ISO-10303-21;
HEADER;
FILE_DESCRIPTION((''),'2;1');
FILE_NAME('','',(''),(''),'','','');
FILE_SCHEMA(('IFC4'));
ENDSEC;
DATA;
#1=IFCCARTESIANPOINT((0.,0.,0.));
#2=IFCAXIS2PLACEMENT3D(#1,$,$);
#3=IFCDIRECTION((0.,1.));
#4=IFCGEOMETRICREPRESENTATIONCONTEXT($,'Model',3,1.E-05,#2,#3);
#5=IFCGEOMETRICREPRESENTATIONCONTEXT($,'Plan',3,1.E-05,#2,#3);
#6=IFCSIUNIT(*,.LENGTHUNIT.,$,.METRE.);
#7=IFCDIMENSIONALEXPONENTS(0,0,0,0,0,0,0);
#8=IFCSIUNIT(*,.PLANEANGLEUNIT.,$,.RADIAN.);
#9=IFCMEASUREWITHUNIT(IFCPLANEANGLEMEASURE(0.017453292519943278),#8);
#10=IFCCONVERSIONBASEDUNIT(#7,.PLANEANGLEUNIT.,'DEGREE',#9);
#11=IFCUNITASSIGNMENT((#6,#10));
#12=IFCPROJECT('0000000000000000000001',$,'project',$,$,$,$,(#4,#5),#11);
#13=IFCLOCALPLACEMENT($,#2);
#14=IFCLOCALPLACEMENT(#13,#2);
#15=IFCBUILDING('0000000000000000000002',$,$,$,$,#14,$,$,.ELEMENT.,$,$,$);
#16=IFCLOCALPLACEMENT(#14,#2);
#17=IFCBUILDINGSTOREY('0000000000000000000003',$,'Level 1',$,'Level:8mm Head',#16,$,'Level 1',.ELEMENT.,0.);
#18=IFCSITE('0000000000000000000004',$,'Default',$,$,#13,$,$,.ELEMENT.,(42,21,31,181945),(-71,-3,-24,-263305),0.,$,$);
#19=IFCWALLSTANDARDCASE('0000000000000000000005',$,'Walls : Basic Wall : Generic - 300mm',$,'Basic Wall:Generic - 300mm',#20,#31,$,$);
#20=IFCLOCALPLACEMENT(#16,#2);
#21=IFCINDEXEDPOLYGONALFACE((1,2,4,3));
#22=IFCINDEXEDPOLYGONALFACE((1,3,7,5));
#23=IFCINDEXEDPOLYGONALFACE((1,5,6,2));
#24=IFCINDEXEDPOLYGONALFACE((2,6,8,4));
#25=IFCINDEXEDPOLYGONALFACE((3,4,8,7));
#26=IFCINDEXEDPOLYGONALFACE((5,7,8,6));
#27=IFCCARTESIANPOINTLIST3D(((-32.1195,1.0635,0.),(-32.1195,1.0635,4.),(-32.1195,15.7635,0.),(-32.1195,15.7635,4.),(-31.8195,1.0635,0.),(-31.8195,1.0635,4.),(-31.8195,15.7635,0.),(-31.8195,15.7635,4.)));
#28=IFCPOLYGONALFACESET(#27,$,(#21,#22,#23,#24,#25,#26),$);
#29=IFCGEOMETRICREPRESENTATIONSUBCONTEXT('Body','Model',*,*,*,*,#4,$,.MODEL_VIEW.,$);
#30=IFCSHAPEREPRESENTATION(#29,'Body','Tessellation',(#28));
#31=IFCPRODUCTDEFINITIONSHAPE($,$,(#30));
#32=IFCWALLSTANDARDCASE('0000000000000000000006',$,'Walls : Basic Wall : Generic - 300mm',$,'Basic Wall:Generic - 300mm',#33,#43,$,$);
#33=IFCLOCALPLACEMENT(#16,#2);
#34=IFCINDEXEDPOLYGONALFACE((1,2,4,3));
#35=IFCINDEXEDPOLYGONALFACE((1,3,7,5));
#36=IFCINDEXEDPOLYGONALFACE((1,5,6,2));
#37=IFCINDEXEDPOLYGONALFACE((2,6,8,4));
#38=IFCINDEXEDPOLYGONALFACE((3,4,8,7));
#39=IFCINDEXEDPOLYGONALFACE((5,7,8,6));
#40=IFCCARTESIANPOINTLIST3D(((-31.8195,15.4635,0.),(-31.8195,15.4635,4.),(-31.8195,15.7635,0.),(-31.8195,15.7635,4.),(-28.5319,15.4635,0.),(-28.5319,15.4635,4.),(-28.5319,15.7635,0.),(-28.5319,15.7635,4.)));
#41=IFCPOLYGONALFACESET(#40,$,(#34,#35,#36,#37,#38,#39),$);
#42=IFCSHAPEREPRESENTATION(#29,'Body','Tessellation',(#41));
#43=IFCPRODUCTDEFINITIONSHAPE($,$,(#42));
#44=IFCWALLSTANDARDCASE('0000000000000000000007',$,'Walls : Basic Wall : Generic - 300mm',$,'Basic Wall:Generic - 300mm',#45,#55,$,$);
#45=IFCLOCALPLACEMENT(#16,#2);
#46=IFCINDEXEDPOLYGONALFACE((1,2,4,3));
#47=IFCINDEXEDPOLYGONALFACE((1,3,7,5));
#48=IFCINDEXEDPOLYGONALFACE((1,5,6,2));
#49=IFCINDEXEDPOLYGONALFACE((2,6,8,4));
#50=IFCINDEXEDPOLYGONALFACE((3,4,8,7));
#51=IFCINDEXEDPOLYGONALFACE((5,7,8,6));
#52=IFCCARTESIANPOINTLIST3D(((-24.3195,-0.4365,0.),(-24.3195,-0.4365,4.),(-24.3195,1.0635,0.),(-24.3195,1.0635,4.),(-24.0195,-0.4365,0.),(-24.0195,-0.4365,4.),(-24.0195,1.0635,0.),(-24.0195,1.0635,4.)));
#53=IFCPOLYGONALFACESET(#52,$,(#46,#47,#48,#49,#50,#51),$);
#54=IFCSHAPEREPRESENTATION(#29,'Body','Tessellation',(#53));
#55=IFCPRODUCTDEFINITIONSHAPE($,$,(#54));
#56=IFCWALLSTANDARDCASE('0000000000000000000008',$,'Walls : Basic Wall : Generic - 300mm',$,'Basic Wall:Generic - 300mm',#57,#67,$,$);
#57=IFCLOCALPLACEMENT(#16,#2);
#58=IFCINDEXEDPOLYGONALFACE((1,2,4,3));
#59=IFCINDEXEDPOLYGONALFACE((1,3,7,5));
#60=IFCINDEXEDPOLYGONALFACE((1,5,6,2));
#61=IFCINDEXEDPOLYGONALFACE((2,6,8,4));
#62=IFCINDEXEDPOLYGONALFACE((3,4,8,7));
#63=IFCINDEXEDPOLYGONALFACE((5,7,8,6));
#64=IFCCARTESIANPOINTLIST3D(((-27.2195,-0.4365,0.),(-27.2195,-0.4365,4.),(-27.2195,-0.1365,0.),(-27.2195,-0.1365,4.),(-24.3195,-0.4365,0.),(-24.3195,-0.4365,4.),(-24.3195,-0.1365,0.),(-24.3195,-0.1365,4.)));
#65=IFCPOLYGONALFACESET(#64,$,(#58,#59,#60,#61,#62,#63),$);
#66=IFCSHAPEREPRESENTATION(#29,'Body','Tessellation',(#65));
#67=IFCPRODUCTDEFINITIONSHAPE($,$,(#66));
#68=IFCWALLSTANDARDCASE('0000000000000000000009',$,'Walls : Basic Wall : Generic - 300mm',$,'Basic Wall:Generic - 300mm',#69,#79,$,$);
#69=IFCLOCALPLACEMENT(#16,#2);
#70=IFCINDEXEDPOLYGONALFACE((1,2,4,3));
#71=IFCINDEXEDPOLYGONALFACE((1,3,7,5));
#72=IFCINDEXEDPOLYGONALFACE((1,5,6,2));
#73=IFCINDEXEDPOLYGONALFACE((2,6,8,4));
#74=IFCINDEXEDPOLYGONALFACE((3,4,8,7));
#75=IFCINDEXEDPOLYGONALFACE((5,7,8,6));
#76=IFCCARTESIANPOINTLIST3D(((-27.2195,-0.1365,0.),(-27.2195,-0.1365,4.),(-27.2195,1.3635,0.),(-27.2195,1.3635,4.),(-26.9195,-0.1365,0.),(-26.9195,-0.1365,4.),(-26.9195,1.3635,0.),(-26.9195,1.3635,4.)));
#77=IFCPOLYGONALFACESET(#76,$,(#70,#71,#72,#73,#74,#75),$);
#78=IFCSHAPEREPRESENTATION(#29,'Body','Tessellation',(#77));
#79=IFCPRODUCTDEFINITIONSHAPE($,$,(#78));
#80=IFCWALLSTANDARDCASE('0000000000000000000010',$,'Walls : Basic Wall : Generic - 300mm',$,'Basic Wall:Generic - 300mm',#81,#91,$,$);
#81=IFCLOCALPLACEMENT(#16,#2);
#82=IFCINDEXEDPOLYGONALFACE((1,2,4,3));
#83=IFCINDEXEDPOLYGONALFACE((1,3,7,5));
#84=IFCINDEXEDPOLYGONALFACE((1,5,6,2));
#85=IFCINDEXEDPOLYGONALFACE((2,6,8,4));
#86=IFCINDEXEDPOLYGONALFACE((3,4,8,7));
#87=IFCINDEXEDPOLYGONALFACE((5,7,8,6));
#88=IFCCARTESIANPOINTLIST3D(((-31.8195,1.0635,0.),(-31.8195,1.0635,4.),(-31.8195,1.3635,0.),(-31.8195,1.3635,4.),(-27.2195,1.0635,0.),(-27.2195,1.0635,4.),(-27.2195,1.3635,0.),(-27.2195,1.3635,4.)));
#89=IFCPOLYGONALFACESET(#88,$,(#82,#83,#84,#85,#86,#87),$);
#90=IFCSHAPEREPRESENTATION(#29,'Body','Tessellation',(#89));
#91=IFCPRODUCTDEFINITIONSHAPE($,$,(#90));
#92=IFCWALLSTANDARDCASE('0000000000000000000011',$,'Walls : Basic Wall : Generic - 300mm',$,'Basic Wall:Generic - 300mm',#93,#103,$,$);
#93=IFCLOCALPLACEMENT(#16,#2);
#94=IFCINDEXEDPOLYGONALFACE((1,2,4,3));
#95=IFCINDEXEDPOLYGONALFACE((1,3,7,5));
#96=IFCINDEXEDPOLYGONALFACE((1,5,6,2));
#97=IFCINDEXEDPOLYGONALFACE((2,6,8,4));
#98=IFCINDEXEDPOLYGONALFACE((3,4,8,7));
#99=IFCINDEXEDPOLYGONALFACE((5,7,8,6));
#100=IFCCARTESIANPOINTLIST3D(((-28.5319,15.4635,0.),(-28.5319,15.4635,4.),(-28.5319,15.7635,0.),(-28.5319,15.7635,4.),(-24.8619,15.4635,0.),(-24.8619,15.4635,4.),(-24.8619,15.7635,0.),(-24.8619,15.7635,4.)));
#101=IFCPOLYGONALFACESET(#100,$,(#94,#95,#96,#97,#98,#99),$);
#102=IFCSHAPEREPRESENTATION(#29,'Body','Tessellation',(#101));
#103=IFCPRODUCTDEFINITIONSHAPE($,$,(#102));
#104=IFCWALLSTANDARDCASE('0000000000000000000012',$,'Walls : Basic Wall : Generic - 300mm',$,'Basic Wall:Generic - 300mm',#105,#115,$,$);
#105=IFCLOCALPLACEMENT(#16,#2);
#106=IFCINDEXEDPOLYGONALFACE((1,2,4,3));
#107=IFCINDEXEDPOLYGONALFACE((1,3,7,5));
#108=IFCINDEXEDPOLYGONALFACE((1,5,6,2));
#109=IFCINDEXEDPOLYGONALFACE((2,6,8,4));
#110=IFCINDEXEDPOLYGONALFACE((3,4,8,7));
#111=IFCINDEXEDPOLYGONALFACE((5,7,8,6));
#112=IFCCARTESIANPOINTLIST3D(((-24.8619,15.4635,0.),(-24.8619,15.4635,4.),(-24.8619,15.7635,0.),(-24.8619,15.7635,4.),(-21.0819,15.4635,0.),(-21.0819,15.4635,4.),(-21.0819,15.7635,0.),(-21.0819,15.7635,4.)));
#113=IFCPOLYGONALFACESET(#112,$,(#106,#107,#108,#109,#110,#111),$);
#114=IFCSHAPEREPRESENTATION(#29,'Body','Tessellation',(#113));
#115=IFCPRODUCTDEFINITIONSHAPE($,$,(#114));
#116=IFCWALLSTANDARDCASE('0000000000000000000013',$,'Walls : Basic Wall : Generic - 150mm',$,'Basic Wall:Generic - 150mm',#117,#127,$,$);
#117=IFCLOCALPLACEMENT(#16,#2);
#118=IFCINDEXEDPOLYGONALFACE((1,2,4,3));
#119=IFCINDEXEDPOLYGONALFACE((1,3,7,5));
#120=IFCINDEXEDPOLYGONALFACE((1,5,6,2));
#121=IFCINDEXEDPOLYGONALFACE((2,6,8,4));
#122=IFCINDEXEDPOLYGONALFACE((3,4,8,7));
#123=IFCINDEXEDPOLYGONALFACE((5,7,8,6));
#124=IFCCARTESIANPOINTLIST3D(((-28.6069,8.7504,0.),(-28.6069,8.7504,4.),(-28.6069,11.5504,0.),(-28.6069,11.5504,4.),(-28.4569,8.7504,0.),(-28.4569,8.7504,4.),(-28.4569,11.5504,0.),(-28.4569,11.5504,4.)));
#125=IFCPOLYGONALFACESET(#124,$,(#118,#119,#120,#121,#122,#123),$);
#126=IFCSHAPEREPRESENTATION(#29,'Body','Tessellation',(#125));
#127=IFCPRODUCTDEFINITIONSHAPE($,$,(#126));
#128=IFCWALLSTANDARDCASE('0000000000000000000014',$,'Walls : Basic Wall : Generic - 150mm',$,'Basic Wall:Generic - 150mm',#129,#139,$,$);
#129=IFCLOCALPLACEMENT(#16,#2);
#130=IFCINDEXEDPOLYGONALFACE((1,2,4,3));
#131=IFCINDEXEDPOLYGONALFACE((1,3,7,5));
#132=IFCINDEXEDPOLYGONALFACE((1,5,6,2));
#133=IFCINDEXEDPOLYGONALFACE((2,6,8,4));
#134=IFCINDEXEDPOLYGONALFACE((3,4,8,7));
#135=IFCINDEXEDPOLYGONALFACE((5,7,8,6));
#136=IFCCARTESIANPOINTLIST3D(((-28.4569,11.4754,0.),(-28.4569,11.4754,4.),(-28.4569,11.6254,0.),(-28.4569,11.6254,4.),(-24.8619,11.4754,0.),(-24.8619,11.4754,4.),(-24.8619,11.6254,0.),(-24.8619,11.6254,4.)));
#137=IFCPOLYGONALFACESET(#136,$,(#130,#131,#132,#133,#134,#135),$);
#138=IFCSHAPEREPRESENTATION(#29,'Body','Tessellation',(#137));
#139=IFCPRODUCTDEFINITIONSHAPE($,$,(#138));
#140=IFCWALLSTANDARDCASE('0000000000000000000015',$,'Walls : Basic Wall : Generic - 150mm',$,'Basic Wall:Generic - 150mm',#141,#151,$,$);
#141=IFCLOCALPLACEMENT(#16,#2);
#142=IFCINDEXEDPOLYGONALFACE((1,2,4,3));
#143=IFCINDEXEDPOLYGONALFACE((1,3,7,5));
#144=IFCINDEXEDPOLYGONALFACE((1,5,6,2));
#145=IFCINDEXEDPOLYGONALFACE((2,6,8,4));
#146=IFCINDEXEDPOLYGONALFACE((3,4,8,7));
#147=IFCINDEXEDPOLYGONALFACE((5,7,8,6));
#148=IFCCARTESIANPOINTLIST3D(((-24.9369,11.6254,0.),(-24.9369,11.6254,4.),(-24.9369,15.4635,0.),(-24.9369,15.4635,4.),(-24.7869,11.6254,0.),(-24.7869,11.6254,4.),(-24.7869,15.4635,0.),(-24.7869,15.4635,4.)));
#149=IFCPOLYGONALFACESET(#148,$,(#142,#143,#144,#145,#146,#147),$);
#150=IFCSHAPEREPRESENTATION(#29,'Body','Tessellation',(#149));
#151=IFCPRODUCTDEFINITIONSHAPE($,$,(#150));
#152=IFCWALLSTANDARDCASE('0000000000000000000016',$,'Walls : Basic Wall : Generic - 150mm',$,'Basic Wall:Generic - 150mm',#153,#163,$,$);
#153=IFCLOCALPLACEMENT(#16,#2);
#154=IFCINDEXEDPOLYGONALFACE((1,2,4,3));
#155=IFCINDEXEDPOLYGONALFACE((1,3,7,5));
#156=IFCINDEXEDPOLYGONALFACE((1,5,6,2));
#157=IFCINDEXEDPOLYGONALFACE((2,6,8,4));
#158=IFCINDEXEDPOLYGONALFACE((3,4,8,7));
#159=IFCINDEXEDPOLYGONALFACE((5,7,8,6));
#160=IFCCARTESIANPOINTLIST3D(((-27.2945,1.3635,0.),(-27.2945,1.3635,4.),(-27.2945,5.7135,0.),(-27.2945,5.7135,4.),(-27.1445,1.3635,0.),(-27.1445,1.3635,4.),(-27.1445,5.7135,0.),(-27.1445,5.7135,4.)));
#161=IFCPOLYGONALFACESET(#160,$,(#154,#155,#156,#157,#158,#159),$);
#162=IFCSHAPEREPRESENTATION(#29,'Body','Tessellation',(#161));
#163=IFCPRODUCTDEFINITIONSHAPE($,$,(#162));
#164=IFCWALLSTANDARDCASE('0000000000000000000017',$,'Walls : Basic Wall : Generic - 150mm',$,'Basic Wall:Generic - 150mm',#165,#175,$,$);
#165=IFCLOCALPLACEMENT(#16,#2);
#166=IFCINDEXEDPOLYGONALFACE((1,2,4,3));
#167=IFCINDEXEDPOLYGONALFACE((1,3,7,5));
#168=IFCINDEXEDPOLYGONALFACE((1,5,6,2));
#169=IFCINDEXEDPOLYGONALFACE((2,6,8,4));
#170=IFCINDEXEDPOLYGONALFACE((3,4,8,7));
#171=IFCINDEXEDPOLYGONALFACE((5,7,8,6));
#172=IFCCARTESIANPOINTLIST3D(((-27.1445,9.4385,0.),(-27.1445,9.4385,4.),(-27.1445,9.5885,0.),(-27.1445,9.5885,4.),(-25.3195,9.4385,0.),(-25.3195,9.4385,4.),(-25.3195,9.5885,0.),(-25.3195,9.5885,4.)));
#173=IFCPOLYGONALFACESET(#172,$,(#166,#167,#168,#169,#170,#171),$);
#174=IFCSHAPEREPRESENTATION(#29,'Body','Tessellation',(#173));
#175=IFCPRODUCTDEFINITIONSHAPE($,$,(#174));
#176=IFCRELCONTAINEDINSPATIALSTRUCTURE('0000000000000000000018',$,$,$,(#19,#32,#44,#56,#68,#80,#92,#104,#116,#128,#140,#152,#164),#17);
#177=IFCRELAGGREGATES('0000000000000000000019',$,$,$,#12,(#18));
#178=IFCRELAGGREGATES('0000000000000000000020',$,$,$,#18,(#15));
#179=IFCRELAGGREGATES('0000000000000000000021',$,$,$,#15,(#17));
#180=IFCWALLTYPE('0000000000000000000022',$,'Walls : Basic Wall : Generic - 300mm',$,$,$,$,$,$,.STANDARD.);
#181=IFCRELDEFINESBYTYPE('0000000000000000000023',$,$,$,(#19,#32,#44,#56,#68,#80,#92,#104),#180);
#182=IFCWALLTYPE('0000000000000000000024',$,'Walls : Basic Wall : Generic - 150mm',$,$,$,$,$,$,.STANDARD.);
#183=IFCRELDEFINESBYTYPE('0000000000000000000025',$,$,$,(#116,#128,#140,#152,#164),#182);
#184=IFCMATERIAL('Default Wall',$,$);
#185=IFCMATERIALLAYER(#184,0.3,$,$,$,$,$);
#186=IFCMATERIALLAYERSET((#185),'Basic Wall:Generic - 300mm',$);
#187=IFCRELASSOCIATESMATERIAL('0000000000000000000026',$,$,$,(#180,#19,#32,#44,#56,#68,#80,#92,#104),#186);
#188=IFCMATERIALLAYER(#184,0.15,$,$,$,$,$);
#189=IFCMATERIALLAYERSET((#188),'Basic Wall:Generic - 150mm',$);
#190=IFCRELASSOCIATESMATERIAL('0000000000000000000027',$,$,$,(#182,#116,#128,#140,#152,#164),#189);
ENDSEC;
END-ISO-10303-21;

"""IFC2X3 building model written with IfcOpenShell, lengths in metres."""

from ifc_helpers import new_model, entity, si_unit, converted_unit, direction, frame, frame_2d, origin, place, context, subcontext, project, spatial, rectangle, extrude, material, layer, layer_set, layer_usage, type_object, element, save


model = new_model("IFC2X3")

# Units and contexts
model_context = context("Model", 3, precision=1e-05, world=origin(), true_north=direction((0.0, 1.0)))
plan_context = context("Plan", 3, precision=1e-05, world=origin(), true_north=direction((0.0, 1.0)))
body_context = subcontext(model_context, "Body", "Model", "MODEL_VIEW")
ifc_project = project(units=[si_unit("LENGTHUNIT", "METRE"), converted_unit("PLANEANGLEUNIT", "DEGREE", entity("IfcPlaneAngleMeasure", 0.017453292519943278), si_unit("PLANEANGLEUNIT", "RADIAN"), dimensions=[0, 0, 0, 0, 0, 0, 0])], contexts=[model_context, plan_context])

# Site, building, storey
site_placement = place(None, origin())
site = spatial("IfcSite", under=ifc_project, at=site_placement, Name="Default", CompositionType="ELEMENT", RefLatitude=(42, 21, 31, 181945), RefLongitude=(-71, -3, -24, -263305), RefElevation=0.0)
building_placement = place(site_placement, origin())
building = spatial("IfcBuilding", under=site, at=building_placement, CompositionType="ELEMENT")
storey_placement = place(building_placement, origin())
storey = spatial("IfcBuildingStorey", under=building, at=storey_placement, Name="Level 1", ObjectType="Level:8mm Head", LongName="Level 1", CompositionType="ELEMENT", Elevation=0.0)

# Walls
ifc_material = material(Name="Default Wall")
ifc_layer_1 = layer(ifc_material, 0.3)
ifc_layer_set_1 = layer_set([ifc_layer_1], Name="Basic Wall:Generic - 300mm")
ifc_layer_usage_1 = layer_usage(ifc_layer_set_1, "AXIS2", "NEGATIVE", 0.15)
wall_type_1 = type_object("IfcWallType", Name="Walls : Basic Wall : Generic - 300mm", PredefinedType="STANDARD", material=ifc_layer_set_1)
wall_1_placement = place(storey_placement, frame((-31.9695, 1.0635, 0.0), z_axis=(0.0, 0.0, 1.0), x_axis=(0.0, 1.0, 0.0)))
element("IfcWallStandardCase", 1, at=wall_1_placement, inside=storey, type_object=wall_type_1, material=ifc_layer_usage_1, Name="Walls : Basic Wall : Generic - 300mm", ObjectType="Basic Wall:Generic - 300mm", context=body_context, shape_type="SweptSolid", body=[
    extrude(rectangle(XDim=14.7, YDim=0.3, at=frame_2d((7.35, 0.0), x_axis=(-1.0, 0.0))), origin(), (0.0, 0.0, 1.0), 4.0),
])
wall_2_placement = place(storey_placement, frame((-31.8195, 15.6135, 0.0)))
element("IfcWallStandardCase", 2, at=wall_2_placement, inside=storey, type_object=wall_type_1, material=ifc_layer_usage_1, Name="Walls : Basic Wall : Generic - 300mm", ObjectType="Basic Wall:Generic - 300mm", context=body_context, shape_type="SweptSolid", body=[
    extrude(rectangle(XDim=3.2876, YDim=0.3, at=frame_2d((1.6438, 0.0), x_axis=(-1.0, 0.0))), origin(), (0.0, 0.0, 1.0), 4.0),
])
wall_3_placement = place(storey_placement, frame((-24.1695, 1.0635, 0.0), z_axis=(0.0, 0.0, 1.0), x_axis=(0.0, -1.0, 0.0)))
element("IfcWallStandardCase", 3, at=wall_3_placement, inside=storey, type_object=wall_type_1, material=ifc_layer_usage_1, Name="Walls : Basic Wall : Generic - 300mm", ObjectType="Basic Wall:Generic - 300mm", context=body_context, shape_type="SweptSolid", body=[
    extrude(rectangle(XDim=1.5, YDim=0.3, at=frame_2d((0.75, 0.0), x_axis=(-1.0, 0.0))), origin(), (0.0, 0.0, 1.0), 4.0),
])
wall_4_placement = place(storey_placement, frame((-24.3195, -0.2865, 0.0), z_axis=(0.0, 0.0, 1.0), x_axis=(-1.0, 0.0, 0.0)))
element("IfcWallStandardCase", 4, at=wall_4_placement, inside=storey, type_object=wall_type_1, material=ifc_layer_usage_1, Name="Walls : Basic Wall : Generic - 300mm", ObjectType="Basic Wall:Generic - 300mm", context=body_context, shape_type="SweptSolid", body=[
    extrude(rectangle(XDim=2.9, YDim=0.3, at=frame_2d((1.45, 0.0), x_axis=(-1.0, 0.0))), origin(), (0.0, 0.0, 1.0), 4.0),
])
wall_5_placement = place(storey_placement, frame((-27.0695, -0.1365, 0.0), z_axis=(0.0, 0.0, 1.0), x_axis=(0.0, 1.0, 0.0)))
element("IfcWallStandardCase", 5, at=wall_5_placement, inside=storey, type_object=wall_type_1, material=ifc_layer_usage_1, Name="Walls : Basic Wall : Generic - 300mm", ObjectType="Basic Wall:Generic - 300mm", context=body_context, shape_type="SweptSolid", body=[
    extrude(rectangle(XDim=1.5, YDim=0.3, at=frame_2d((0.75, 0.0), x_axis=(-1.0, 0.0))), origin(), (0.0, 0.0, 1.0), 4.0),
])
wall_6_placement = place(storey_placement, frame((-27.2195, 1.2135, 0.0), z_axis=(0.0, 0.0, 1.0), x_axis=(-1.0, 0.0, 0.0)))
element("IfcWallStandardCase", 6, at=wall_6_placement, inside=storey, type_object=wall_type_1, material=ifc_layer_usage_1, Name="Walls : Basic Wall : Generic - 300mm", ObjectType="Basic Wall:Generic - 300mm", context=body_context, shape_type="SweptSolid", body=[
    extrude(rectangle(XDim=4.6, YDim=0.3, at=frame_2d((2.3, 0.0), x_axis=(-1.0, 0.0))), origin(), (0.0, 0.0, 1.0), 4.0),
])
wall_7_placement = place(storey_placement, frame((-28.5319, 15.6135, 0.0)))
element("IfcWallStandardCase", 7, at=wall_7_placement, inside=storey, type_object=wall_type_1, material=ifc_layer_usage_1, Name="Walls : Basic Wall : Generic - 300mm", ObjectType="Basic Wall:Generic - 300mm", context=body_context, shape_type="SweptSolid", body=[
    extrude(rectangle(XDim=3.67, YDim=0.3, at=frame_2d((1.835, 0.0), x_axis=(-1.0, 0.0))), origin(), (0.0, 0.0, 1.0), 4.0),
])
wall_8_placement = place(storey_placement, frame((-24.8619, 15.6135, 0.0)))
element("IfcWallStandardCase", 8, at=wall_8_placement, inside=storey, type_object=wall_type_1, material=ifc_layer_usage_1, Name="Walls : Basic Wall : Generic - 300mm", ObjectType="Basic Wall:Generic - 300mm", context=body_context, shape_type="SweptSolid", body=[
    extrude(rectangle(XDim=3.78, YDim=0.3, at=frame_2d((1.89, 0.0), x_axis=(-1.0, 0.0))), origin(), (0.0, 0.0, 1.0), 4.0),
])
ifc_layer_2 = layer(ifc_material, 0.15)
ifc_layer_set_2 = layer_set([ifc_layer_2], Name="Basic Wall:Generic - 150mm")
ifc_layer_usage_2 = layer_usage(ifc_layer_set_2, "AXIS2", "NEGATIVE", 0.075)
wall_type_2 = type_object("IfcWallType", Name="Walls : Basic Wall : Generic - 150mm", PredefinedType="STANDARD", material=ifc_layer_set_2)
wall_9_placement = place(storey_placement, frame((-28.5319, 8.7504, 0.0), z_axis=(0.0, 0.0, 1.0), x_axis=(0.0, 1.0, 0.0)))
element("IfcWallStandardCase", 9, at=wall_9_placement, inside=storey, type_object=wall_type_2, material=ifc_layer_usage_2, Name="Walls : Basic Wall : Generic - 150mm", ObjectType="Basic Wall:Generic - 150mm", context=body_context, shape_type="SweptSolid", body=[
    extrude(rectangle(XDim=2.8, YDim=0.15, at=frame_2d((1.4, 0.0), x_axis=(-1.0, 0.0))), origin(), (0.0, 0.0, 1.0), 4.0),
])
wall_10_placement = place(storey_placement, frame((-28.4569, 11.5504, 0.0)))
element("IfcWallStandardCase", 10, at=wall_10_placement, inside=storey, type_object=wall_type_2, material=ifc_layer_usage_2, Name="Walls : Basic Wall : Generic - 150mm", ObjectType="Basic Wall:Generic - 150mm", context=body_context, shape_type="SweptSolid", body=[
    extrude(rectangle(XDim=3.595, YDim=0.15, at=frame_2d((1.7975, 0.0), x_axis=(-1.0, 0.0))), origin(), (0.0, 0.0, 1.0), 4.0),
])
wall_11_placement = place(storey_placement, frame((-24.8619, 11.6254, 0.0), z_axis=(0.0, 0.0, 1.0), x_axis=(0.0, 1.0, 0.0)))
element("IfcWallStandardCase", 11, at=wall_11_placement, inside=storey, type_object=wall_type_2, material=ifc_layer_usage_2, Name="Walls : Basic Wall : Generic - 150mm", ObjectType="Basic Wall:Generic - 150mm", context=body_context, shape_type="SweptSolid", body=[
    extrude(rectangle(XDim=3.8381, YDim=0.15, at=frame_2d((1.919, 0.0), x_axis=(-1.0, 0.0))), origin(), (0.0, 0.0, 1.0), 4.0),
])
wall_12_placement = place(storey_placement, frame((-27.2195, 1.3635, 0.0), z_axis=(0.0, 0.0, 1.0), x_axis=(0.0, 1.0, 0.0)))
element("IfcWallStandardCase", 12, at=wall_12_placement, inside=storey, type_object=wall_type_2, material=ifc_layer_usage_2, Name="Walls : Basic Wall : Generic - 150mm", ObjectType="Basic Wall:Generic - 150mm", context=body_context, shape_type="SweptSolid", body=[
    extrude(rectangle(XDim=4.35, YDim=0.15, at=frame_2d((2.175, 0.0), x_axis=(-1.0, 0.0))), origin(), (0.0, 0.0, 1.0), 4.0),
])
wall_13_placement = place(storey_placement, frame((-27.1445, 9.5135, 0.0)))
element("IfcWallStandardCase", 13, at=wall_13_placement, inside=storey, type_object=wall_type_2, material=ifc_layer_usage_2, Name="Walls : Basic Wall : Generic - 150mm", ObjectType="Basic Wall:Generic - 150mm", context=body_context, shape_type="SweptSolid", body=[
    extrude(rectangle(XDim=1.825, YDim=0.15, at=frame_2d((0.9125, 0.0), x_axis=(-1.0, 0.0))), origin(), (0.0, 0.0, 1.0), 4.0),
])

save(model, "model.ifc")
